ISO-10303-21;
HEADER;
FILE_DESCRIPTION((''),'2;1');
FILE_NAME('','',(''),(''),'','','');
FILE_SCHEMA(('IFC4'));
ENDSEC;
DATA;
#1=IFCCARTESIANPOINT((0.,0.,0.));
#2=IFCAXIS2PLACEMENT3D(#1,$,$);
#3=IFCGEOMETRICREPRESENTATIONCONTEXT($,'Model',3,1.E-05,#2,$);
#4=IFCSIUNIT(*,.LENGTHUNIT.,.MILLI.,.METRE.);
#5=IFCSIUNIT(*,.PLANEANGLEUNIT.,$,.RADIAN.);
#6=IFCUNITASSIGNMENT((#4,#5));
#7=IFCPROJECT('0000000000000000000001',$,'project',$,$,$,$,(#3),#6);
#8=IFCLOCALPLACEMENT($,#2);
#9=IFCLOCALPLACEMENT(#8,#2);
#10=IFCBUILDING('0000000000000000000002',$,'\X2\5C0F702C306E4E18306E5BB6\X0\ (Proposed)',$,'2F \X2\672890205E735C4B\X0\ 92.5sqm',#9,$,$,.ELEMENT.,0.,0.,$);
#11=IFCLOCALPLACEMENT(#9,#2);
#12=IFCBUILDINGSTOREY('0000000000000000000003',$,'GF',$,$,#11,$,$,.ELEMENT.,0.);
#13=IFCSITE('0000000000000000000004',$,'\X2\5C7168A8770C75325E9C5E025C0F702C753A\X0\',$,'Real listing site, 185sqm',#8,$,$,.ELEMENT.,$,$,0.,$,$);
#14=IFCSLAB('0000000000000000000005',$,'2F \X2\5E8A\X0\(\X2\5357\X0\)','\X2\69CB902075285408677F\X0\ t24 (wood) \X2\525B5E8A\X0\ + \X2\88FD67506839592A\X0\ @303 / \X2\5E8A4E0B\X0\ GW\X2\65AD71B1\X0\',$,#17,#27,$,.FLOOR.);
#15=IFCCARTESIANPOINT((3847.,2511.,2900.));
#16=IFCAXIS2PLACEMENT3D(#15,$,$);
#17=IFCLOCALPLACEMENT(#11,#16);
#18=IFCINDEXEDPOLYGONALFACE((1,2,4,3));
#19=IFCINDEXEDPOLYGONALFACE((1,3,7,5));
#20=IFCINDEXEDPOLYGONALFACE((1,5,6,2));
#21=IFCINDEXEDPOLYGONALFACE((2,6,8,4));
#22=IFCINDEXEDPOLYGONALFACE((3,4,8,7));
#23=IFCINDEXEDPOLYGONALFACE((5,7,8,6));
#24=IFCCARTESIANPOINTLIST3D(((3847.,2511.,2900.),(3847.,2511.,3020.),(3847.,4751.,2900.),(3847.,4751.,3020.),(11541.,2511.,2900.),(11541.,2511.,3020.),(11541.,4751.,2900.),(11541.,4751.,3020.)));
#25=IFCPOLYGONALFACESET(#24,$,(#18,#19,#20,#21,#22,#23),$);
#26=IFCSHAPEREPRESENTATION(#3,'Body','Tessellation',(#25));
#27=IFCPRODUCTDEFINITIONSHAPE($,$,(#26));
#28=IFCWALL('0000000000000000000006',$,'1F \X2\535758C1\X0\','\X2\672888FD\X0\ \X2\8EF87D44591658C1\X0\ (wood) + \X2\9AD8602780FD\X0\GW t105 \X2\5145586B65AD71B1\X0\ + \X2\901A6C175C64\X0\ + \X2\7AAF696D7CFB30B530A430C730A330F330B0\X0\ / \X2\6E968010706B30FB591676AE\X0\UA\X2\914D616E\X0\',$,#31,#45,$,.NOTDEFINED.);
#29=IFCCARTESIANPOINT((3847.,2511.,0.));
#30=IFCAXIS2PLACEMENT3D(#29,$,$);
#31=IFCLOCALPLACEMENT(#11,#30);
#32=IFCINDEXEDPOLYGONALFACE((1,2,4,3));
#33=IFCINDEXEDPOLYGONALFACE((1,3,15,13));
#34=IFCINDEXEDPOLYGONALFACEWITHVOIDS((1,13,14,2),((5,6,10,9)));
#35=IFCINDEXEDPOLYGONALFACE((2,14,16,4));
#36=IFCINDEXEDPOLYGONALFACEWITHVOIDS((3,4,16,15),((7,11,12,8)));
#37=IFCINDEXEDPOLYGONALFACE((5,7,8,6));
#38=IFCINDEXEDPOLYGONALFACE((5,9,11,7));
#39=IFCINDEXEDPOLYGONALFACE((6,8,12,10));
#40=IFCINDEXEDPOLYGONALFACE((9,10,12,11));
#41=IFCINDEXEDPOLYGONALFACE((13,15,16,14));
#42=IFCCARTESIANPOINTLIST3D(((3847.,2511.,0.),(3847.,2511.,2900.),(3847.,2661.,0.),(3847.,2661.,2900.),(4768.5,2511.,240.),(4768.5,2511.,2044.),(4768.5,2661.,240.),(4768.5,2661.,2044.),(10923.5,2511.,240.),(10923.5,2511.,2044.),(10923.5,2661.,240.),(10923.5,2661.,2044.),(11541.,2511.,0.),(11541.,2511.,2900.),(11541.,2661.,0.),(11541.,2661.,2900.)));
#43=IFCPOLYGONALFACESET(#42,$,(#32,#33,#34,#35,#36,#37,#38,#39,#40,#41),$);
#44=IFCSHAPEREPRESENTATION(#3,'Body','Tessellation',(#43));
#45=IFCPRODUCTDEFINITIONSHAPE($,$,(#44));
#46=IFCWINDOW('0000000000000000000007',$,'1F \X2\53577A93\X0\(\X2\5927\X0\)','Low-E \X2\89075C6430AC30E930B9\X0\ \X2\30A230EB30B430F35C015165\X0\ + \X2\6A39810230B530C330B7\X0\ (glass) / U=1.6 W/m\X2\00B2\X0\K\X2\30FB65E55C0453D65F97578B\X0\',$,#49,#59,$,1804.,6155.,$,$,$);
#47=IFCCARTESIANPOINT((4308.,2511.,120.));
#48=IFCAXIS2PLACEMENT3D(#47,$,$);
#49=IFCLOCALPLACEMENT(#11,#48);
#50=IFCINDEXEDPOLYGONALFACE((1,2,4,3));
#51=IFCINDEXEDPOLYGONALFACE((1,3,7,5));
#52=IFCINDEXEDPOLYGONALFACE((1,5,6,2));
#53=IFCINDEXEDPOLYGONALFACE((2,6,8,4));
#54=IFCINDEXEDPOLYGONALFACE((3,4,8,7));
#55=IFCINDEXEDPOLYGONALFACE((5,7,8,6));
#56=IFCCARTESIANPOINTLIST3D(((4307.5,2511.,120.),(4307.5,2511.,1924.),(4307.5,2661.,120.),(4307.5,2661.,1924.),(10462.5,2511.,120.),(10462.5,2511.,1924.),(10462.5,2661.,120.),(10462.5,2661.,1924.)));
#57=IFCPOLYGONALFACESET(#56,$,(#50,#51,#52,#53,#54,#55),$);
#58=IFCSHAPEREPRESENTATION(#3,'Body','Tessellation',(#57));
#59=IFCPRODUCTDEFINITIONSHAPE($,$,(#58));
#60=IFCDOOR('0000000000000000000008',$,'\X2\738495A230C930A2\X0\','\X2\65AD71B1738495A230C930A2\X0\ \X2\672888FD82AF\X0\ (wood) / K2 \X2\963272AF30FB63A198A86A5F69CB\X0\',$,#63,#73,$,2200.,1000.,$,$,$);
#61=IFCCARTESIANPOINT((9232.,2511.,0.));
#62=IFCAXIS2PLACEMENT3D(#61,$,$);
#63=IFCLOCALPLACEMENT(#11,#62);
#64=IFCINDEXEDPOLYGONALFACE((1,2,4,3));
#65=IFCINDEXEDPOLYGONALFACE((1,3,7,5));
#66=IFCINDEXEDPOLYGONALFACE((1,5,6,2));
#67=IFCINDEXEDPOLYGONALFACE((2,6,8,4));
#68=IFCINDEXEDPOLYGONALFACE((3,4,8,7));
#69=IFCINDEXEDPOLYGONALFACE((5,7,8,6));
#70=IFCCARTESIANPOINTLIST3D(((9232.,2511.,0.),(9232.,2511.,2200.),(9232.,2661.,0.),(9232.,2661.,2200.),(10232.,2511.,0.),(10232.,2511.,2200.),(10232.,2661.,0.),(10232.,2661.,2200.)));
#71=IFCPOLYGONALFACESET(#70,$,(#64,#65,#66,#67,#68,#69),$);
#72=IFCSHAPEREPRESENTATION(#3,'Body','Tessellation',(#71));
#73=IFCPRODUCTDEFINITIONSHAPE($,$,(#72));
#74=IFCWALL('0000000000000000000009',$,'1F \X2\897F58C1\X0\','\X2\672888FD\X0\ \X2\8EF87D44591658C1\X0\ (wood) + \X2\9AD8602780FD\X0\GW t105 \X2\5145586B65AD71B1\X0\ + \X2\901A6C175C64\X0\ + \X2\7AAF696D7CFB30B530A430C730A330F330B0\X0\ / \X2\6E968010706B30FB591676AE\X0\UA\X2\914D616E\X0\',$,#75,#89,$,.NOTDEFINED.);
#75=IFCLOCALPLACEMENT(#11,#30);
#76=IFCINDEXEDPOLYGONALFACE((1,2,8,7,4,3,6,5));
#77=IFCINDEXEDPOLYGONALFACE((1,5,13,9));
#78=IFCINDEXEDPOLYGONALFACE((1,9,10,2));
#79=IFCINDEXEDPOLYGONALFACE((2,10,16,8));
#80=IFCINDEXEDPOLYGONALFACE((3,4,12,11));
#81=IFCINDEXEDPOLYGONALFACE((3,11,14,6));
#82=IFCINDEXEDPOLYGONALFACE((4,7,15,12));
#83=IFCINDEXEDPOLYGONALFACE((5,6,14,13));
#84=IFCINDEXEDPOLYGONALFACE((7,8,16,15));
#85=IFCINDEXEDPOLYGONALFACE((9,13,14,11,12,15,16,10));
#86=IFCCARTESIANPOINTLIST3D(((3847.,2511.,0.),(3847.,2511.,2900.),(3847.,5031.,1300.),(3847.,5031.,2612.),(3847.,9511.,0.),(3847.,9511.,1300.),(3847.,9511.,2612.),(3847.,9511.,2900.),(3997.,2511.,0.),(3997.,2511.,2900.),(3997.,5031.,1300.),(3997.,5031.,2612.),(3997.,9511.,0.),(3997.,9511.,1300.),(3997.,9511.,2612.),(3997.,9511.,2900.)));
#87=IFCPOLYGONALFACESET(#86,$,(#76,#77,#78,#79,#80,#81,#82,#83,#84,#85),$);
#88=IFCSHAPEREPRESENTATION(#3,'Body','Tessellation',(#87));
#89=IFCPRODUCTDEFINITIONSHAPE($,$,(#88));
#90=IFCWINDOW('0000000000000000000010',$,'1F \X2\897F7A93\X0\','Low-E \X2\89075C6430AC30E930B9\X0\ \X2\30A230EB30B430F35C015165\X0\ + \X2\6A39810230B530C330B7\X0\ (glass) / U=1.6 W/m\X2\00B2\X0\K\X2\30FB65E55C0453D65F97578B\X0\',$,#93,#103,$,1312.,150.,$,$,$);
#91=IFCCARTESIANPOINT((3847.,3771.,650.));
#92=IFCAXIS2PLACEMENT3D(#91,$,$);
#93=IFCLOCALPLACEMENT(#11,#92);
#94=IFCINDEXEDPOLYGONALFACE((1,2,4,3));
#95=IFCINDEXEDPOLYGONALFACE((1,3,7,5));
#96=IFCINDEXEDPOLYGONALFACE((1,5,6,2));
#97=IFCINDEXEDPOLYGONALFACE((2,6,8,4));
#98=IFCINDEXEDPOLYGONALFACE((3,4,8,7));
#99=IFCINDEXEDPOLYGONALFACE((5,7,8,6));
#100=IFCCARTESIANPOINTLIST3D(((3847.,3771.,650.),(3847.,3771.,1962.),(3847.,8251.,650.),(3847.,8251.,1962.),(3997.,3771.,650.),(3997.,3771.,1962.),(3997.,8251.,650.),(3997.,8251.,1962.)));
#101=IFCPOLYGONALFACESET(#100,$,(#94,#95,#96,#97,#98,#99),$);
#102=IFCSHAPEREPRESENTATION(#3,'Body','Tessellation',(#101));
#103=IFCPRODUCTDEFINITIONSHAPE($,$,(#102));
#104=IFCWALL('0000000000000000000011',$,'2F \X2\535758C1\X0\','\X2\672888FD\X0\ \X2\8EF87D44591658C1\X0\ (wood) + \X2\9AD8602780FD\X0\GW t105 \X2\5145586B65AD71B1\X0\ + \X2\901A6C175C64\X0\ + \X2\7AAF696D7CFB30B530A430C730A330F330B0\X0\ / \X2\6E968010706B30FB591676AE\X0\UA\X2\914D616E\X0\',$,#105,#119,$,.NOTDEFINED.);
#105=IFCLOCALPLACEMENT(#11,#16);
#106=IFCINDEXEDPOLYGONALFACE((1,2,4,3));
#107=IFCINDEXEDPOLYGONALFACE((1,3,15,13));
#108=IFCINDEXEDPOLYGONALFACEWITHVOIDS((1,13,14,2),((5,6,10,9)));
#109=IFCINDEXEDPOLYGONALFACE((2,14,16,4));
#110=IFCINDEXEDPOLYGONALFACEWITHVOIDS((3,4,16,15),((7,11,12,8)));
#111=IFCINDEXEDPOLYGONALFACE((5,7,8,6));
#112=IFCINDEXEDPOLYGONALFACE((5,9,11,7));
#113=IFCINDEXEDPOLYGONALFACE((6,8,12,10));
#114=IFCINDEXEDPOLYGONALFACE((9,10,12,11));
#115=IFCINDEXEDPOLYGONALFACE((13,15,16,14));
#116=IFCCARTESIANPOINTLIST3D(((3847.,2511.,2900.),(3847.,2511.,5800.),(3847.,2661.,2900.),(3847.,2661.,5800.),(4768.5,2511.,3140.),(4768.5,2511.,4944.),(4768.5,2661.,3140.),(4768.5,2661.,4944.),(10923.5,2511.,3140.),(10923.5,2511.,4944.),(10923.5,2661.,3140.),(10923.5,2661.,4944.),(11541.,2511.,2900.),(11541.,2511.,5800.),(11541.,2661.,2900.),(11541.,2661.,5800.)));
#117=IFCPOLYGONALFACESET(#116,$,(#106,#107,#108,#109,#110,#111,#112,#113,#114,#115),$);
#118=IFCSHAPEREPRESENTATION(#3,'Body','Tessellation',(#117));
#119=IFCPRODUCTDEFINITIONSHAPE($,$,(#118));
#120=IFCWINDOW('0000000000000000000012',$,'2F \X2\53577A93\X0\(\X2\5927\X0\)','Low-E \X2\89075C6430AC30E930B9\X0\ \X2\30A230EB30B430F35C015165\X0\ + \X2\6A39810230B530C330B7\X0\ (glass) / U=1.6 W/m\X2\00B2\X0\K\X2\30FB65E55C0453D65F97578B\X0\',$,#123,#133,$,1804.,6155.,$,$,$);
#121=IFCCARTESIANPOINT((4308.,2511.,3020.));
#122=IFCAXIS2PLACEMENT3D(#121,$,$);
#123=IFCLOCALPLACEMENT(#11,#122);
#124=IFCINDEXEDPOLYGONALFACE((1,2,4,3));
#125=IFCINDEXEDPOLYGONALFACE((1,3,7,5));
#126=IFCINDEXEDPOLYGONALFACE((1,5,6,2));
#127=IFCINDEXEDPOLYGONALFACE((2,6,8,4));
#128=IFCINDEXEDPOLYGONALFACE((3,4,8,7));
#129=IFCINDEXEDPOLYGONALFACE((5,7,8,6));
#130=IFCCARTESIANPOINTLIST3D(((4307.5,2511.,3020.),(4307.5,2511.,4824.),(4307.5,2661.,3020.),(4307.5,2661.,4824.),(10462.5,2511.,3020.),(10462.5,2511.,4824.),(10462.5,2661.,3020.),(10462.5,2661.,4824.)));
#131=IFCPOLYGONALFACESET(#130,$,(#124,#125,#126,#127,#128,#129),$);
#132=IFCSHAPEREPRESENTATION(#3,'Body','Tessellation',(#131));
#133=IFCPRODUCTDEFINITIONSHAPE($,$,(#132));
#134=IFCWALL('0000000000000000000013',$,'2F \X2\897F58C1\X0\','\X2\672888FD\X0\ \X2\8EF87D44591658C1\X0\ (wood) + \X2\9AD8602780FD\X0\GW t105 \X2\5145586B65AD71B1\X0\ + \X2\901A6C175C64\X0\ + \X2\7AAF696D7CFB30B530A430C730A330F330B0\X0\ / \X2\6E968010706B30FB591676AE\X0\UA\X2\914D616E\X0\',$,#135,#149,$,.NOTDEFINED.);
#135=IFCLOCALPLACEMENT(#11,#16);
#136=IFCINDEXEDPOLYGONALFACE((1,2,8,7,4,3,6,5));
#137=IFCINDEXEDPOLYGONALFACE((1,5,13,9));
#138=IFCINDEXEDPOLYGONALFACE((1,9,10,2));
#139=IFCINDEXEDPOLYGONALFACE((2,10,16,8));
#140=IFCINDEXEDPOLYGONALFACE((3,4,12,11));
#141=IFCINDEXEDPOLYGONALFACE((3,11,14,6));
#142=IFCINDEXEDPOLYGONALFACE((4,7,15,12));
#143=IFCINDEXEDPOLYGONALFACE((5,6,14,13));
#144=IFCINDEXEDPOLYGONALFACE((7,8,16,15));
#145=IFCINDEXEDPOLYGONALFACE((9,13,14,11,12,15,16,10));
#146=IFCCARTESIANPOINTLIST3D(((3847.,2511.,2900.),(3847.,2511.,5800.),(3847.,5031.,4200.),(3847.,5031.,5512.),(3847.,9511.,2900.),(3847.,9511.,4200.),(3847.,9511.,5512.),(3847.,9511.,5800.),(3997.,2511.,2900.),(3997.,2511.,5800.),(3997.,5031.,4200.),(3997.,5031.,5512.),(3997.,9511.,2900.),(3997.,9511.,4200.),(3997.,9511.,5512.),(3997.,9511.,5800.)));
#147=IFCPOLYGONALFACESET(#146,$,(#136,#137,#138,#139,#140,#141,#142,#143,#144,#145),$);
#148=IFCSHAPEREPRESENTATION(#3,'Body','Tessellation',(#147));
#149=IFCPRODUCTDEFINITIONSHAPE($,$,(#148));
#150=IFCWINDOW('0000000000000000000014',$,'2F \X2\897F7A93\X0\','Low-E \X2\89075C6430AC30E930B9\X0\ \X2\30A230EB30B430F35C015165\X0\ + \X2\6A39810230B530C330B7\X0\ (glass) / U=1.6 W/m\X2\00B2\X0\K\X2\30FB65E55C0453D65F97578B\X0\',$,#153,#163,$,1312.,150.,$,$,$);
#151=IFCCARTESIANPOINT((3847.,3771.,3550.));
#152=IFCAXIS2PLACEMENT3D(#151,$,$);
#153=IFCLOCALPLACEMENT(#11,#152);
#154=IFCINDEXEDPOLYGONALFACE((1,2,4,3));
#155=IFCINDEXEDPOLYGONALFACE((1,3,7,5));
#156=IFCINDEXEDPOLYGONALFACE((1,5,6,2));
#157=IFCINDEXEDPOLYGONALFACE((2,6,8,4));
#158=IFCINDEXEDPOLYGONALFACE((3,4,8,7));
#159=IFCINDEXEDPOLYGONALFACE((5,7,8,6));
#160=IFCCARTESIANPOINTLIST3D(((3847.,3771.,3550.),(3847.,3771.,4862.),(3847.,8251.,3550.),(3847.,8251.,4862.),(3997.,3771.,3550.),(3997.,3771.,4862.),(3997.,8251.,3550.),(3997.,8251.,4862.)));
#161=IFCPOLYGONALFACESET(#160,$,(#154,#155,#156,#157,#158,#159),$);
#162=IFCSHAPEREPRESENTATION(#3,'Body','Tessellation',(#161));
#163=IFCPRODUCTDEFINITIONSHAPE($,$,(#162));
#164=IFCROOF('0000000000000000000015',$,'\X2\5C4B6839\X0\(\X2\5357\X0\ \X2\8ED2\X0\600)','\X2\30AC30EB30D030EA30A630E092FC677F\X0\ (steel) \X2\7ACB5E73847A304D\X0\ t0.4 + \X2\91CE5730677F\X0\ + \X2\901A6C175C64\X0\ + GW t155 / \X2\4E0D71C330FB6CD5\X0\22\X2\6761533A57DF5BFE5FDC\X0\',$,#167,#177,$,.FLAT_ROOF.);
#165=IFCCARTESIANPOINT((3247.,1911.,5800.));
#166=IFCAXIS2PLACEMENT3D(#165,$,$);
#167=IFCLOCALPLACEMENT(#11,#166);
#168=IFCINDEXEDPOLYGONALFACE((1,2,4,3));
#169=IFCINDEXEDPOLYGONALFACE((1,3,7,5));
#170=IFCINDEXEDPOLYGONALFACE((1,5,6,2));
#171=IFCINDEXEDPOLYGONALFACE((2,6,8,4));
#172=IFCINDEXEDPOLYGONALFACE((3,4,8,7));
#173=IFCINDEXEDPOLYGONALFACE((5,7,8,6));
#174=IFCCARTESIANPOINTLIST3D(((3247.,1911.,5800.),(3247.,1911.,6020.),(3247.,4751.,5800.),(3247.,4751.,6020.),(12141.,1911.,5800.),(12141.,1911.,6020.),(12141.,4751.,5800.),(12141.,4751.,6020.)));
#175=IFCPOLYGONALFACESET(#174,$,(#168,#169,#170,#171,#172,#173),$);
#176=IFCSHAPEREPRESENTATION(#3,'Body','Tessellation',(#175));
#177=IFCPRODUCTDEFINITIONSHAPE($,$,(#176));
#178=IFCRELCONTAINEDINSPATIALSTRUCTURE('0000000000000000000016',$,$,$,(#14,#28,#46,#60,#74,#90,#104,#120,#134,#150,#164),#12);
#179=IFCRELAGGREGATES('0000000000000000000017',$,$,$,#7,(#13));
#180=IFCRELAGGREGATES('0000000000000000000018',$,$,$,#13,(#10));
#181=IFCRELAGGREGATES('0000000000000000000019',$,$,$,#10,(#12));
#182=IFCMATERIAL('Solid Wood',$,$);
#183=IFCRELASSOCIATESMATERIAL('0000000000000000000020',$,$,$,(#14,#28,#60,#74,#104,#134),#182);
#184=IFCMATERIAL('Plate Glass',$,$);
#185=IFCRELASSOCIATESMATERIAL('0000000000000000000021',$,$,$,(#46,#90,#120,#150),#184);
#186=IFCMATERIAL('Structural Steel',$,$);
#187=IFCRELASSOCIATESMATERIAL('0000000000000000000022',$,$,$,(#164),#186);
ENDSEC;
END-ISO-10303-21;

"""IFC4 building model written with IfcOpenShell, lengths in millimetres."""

from ifc_helpers import new_model, si_unit, frame, frame_2d, origin, place, context, project, spatial, rectangle, extrude, material, element, fill, save


model = new_model("IFC4")

# Units and contexts
model_context = context("Model", 3, precision=1e-05, world=origin())
ifc_project = project(units=[si_unit("LENGTHUNIT", "METRE", prefix="MILLI"), si_unit("PLANEANGLEUNIT", "RADIAN")], contexts=[model_context])

# Site, building, storey
site_placement = place(None, origin())
site = spatial("IfcSite", under=ifc_project, at=site_placement, Name="山梨県甲府市小瀬町", ObjectType="Real listing site, 185sqm", CompositionType="ELEMENT", RefElevation=0.0)
building_placement = place(site_placement, origin())
building = spatial("IfcBuilding", under=site, at=building_placement, Name="小瀬の丘の家 (Proposed)", ObjectType="2F 木造平屋 92.5sqm", CompositionType="ELEMENT", ElevationOfRefHeight=0.0, ElevationOfTerrain=0.0)
storey_placement = place(building_placement, origin())
storey = spatial("IfcBuildingStorey", under=building, at=storey_placement, Name="GF", CompositionType="ELEMENT", Elevation=0.0)

# Slab
ifc_material_1 = material(Name="Solid Wood")
slab_1_placement = place(storey_placement, frame((3847.0, 2511.0, 2900.0)))
element("IfcSlab", 1, at=slab_1_placement, inside=storey, material=ifc_material_1, Name="2F 床(南)", Description="構造用合板 t24 (wood) 剛床 + 製材根太 @303 / 床下 GW断熱", PredefinedType="FLOOR", context=model_context, shape_type="SweptSolid", body=[
    extrude(rectangle(XDim=7694.0, YDim=2240.0, at=frame_2d((3847.0, 1120.0))), frame((3847.0, 2511.0, 2900.0)), (0.0, 0.0, 1.0), 120.0),
])

# Wall, openings, window, door
wall_1_placement = place(storey_placement, frame((3847.0, 2511.0, 0.0)))
wall_1 = element("IfcWall", 2, at=wall_1_placement, inside=storey, material=ifc_material_1, Name="1F 南壁", Description="木製 軸組外壁 (wood) + 高性能GW t105 充填断熱 + 通気層 + 窯業系サイディング / 準耐火・外皮UA配慮", PredefinedType="NOTDEFINED", context=model_context, shape_type="SweptSolid", body=[
    extrude(rectangle(XDim=7694.0, YDim=150.0, at=frame_2d((3847.0, 75.0))), frame((3847.0, 2511.0, 0.0)), (0.0, 0.0, 1.0), 2900.0),
])
opening_1_placement = place(storey_placement, frame((4308.0, 2511.0, 120.0)))
opening_1 = element("IfcOpeningElement", 3, at=opening_1_placement, cuts=wall_1, PredefinedType="NOTDEFINED", context=model_context, shape_type="SweptSolid", body=[
    extrude(rectangle(XDim=6155.0, YDim=150.0, at=frame_2d((3077.0, 75.0))), frame((4308.0, 2511.0, 120.0)), (0.0, 0.0, 1.0), 1804.0),
])
opening_2_placement = place(storey_placement, frame((9232.0, 2511.0, 0.0)))
opening_2 = element("IfcOpeningElement", 4, at=opening_2_placement, cuts=wall_1, PredefinedType="NOTDEFINED", context=model_context, shape_type="SweptSolid", body=[
    extrude(rectangle(XDim=1000.0, YDim=150.0, at=frame_2d((500.0, 75.0))), frame((9232.0, 2511.0, 0.0)), (0.0, 0.0, 1.0), 2200.0),
])
ifc_material_2 = material(Name="Plate Glass")
window_1_placement = place(storey_placement, frame((4308.0, 2511.0, 120.0)))
window_1 = element("IfcWindow", 5, at=window_1_placement, inside=storey, material=ifc_material_2, Name="1F 南窓(大)", Description="Low-E 複層ガラス アルゴン封入 + 樹脂サッシ (glass) / U=1.6 W/m²K・日射取得型", OverallHeight=1804.0, OverallWidth=6155.0, context=model_context, shape_type="SweptSolid", body=[
    extrude(rectangle(XDim=6155.0, YDim=150.0, at=frame_2d((3077.0, 75.0))), frame((4308.0, 2511.0, 120.0)), (0.0, 0.0, 1.0), 1804.0),
])
fill(opening_1, window_1)
door_placement = place(storey_placement, frame((9232.0, 2511.0, 0.0)))
door = element("IfcDoor", 6, at=door_placement, inside=storey, material=ifc_material_1, Name="玄関ドア", Description="断熱玄関ドア 木製芯 (wood) / K2 防犯・採風機構", OverallHeight=2200.0, OverallWidth=1000.0, context=model_context, shape_type="SweptSolid", body=[
    extrude(rectangle(XDim=1000.0, YDim=150.0, at=frame_2d((500.0, 75.0))), frame((9232.0, 2511.0, 0.0)), (0.0, 0.0, 1.0), 2200.0),
])
fill(opening_2, door)

# Walls, openings, windows
wall_2_placement = place(storey_placement, frame((3847.0, 2511.0, 0.0)))
wall_2 = element("IfcWall", 7, at=wall_2_placement, inside=storey, material=ifc_material_1, Name="1F 西壁", Description="木製 軸組外壁 (wood) + 高性能GW t105 充填断熱 + 通気層 + 窯業系サイディング / 準耐火・外皮UA配慮", PredefinedType="NOTDEFINED", context=model_context, shape_type="SweptSolid", body=[
    extrude(rectangle(XDim=150.0, YDim=7000.0, at=frame_2d((75.0, 3500.0))), frame((3847.0, 2511.0, 0.0)), (0.0, 0.0, 1.0), 2900.0),
])
opening_3_placement = place(storey_placement, frame((3847.0, 3771.0, 650.0)))
opening_3 = element("IfcOpeningElement", 8, at=opening_3_placement, cuts=wall_2, PredefinedType="NOTDEFINED", context=model_context, shape_type="SweptSolid", body=[
    extrude(rectangle(XDim=150.0, YDim=4480.0, at=frame_2d((75.0, 2240.0))), frame((3847.0, 3771.0, 650.0)), (0.0, 0.0, 1.0), 1312.0),
])
window_2_placement = place(storey_placement, frame((3847.0, 3771.0, 650.0)))
window_2 = element("IfcWindow", 9, at=window_2_placement, inside=storey, material=ifc_material_2, Name="1F 西窓", Description="Low-E 複層ガラス アルゴン封入 + 樹脂サッシ (glass) / U=1.6 W/m²K・日射取得型", OverallHeight=1312.0, OverallWidth=150.0, context=model_context, shape_type="SweptSolid", body=[
    extrude(rectangle(XDim=150.0, YDim=4480.0, at=frame_2d((75.0, 2240.0))), frame((3847.0, 3771.0, 650.0)), (0.0, 0.0, 1.0), 1312.0),
])
fill(opening_3, window_2)
wall_3_placement = place(storey_placement, frame((3847.0, 2511.0, 2900.0)))
wall_3 = element("IfcWall", 10, at=wall_3_placement, inside=storey, material=ifc_material_1, Name="2F 南壁", Description="木製 軸組外壁 (wood) + 高性能GW t105 充填断熱 + 通気層 + 窯業系サイディング / 準耐火・外皮UA配慮", PredefinedType="NOTDEFINED", context=model_context, shape_type="SweptSolid", body=[
    extrude(rectangle(XDim=7694.0, YDim=150.0, at=frame_2d((3847.0, 75.0))), frame((3847.0, 2511.0, 2900.0)), (0.0, 0.0, 1.0), 2900.0),
])
opening_4_placement = place(storey_placement, frame((4308.0, 2511.0, 3020.0)))
opening_4 = element("IfcOpeningElement", 11, at=opening_4_placement, cuts=wall_3, PredefinedType="NOTDEFINED", context=model_context, shape_type="SweptSolid", body=[
    extrude(rectangle(XDim=6155.0, YDim=150.0, at=frame_2d((3077.0, 75.0))), frame((4308.0, 2511.0, 3020.0)), (0.0, 0.0, 1.0), 1804.0),
])
window_3_placement = place(storey_placement, frame((4308.0, 2511.0, 3020.0)))
window_3 = element("IfcWindow", 12, at=window_3_placement, inside=storey, material=ifc_material_2, Name="2F 南窓(大)", Description="Low-E 複層ガラス アルゴン封入 + 樹脂サッシ (glass) / U=1.6 W/m²K・日射取得型", OverallHeight=1804.0, OverallWidth=6155.0, context=model_context, shape_type="SweptSolid", body=[
    extrude(rectangle(XDim=6155.0, YDim=150.0, at=frame_2d((3077.0, 75.0))), frame((4308.0, 2511.0, 3020.0)), (0.0, 0.0, 1.0), 1804.0),
])
fill(opening_4, window_3)
wall_4_placement = place(storey_placement, frame((3847.0, 2511.0, 2900.0)))
wall_4 = element("IfcWall", 13, at=wall_4_placement, inside=storey, material=ifc_material_1, Name="2F 西壁", Description="木製 軸組外壁 (wood) + 高性能GW t105 充填断熱 + 通気層 + 窯業系サイディング / 準耐火・外皮UA配慮", PredefinedType="NOTDEFINED", context=model_context, shape_type="SweptSolid", body=[
    extrude(rectangle(XDim=150.0, YDim=7000.0, at=frame_2d((75.0, 3500.0))), frame((3847.0, 2511.0, 2900.0)), (0.0, 0.0, 1.0), 2900.0),
])
opening_5_placement = place(storey_placement, frame((3847.0, 3771.0, 3550.0)))
opening_5 = element("IfcOpeningElement", 14, at=opening_5_placement, cuts=wall_4, PredefinedType="NOTDEFINED", context=model_context, shape_type="SweptSolid", body=[
    extrude(rectangle(XDim=150.0, YDim=4480.0, at=frame_2d((75.0, 2240.0))), frame((3847.0, 3771.0, 3550.0)), (0.0, 0.0, 1.0), 1312.0),
])
window_4_placement = place(storey_placement, frame((3847.0, 3771.0, 3550.0)))
window_4 = element("IfcWindow", 15, at=window_4_placement, inside=storey, material=ifc_material_2, Name="2F 西窓", Description="Low-E 複層ガラス アルゴン封入 + 樹脂サッシ (glass) / U=1.6 W/m²K・日射取得型", OverallHeight=1312.0, OverallWidth=150.0, context=model_context, shape_type="SweptSolid", body=[
    extrude(rectangle(XDim=150.0, YDim=4480.0, at=frame_2d((75.0, 2240.0))), frame((3847.0, 3771.0, 3550.0)), (0.0, 0.0, 1.0), 1312.0),
])
fill(opening_5, window_4)

# Roof
ifc_material_3 = material(Name="Structural Steel")
roof_1_placement = place(storey_placement, frame((3247.0, 1911.0, 5800.0)))
element("IfcRoof", 16, at=roof_1_placement, inside=storey, material=ifc_material_3, Name="屋根(南 軒600)", Description="ガルバリウム鋼板 (steel) 立平葺き t0.4 + 野地板 + 通気層 + GW t155 / 不燃・法22条区域対応", PredefinedType="FLAT_ROOF", context=model_context, shape_type="SweptSolid", body=[
    extrude(rectangle(XDim=8894.0, YDim=2840.0, at=frame_2d((4447.0, 1420.0))), frame((3247.0, 1911.0, 5800.0)), (0.0, 0.0, 1.0), 220.0),
])

save(model, "model.ifc")
